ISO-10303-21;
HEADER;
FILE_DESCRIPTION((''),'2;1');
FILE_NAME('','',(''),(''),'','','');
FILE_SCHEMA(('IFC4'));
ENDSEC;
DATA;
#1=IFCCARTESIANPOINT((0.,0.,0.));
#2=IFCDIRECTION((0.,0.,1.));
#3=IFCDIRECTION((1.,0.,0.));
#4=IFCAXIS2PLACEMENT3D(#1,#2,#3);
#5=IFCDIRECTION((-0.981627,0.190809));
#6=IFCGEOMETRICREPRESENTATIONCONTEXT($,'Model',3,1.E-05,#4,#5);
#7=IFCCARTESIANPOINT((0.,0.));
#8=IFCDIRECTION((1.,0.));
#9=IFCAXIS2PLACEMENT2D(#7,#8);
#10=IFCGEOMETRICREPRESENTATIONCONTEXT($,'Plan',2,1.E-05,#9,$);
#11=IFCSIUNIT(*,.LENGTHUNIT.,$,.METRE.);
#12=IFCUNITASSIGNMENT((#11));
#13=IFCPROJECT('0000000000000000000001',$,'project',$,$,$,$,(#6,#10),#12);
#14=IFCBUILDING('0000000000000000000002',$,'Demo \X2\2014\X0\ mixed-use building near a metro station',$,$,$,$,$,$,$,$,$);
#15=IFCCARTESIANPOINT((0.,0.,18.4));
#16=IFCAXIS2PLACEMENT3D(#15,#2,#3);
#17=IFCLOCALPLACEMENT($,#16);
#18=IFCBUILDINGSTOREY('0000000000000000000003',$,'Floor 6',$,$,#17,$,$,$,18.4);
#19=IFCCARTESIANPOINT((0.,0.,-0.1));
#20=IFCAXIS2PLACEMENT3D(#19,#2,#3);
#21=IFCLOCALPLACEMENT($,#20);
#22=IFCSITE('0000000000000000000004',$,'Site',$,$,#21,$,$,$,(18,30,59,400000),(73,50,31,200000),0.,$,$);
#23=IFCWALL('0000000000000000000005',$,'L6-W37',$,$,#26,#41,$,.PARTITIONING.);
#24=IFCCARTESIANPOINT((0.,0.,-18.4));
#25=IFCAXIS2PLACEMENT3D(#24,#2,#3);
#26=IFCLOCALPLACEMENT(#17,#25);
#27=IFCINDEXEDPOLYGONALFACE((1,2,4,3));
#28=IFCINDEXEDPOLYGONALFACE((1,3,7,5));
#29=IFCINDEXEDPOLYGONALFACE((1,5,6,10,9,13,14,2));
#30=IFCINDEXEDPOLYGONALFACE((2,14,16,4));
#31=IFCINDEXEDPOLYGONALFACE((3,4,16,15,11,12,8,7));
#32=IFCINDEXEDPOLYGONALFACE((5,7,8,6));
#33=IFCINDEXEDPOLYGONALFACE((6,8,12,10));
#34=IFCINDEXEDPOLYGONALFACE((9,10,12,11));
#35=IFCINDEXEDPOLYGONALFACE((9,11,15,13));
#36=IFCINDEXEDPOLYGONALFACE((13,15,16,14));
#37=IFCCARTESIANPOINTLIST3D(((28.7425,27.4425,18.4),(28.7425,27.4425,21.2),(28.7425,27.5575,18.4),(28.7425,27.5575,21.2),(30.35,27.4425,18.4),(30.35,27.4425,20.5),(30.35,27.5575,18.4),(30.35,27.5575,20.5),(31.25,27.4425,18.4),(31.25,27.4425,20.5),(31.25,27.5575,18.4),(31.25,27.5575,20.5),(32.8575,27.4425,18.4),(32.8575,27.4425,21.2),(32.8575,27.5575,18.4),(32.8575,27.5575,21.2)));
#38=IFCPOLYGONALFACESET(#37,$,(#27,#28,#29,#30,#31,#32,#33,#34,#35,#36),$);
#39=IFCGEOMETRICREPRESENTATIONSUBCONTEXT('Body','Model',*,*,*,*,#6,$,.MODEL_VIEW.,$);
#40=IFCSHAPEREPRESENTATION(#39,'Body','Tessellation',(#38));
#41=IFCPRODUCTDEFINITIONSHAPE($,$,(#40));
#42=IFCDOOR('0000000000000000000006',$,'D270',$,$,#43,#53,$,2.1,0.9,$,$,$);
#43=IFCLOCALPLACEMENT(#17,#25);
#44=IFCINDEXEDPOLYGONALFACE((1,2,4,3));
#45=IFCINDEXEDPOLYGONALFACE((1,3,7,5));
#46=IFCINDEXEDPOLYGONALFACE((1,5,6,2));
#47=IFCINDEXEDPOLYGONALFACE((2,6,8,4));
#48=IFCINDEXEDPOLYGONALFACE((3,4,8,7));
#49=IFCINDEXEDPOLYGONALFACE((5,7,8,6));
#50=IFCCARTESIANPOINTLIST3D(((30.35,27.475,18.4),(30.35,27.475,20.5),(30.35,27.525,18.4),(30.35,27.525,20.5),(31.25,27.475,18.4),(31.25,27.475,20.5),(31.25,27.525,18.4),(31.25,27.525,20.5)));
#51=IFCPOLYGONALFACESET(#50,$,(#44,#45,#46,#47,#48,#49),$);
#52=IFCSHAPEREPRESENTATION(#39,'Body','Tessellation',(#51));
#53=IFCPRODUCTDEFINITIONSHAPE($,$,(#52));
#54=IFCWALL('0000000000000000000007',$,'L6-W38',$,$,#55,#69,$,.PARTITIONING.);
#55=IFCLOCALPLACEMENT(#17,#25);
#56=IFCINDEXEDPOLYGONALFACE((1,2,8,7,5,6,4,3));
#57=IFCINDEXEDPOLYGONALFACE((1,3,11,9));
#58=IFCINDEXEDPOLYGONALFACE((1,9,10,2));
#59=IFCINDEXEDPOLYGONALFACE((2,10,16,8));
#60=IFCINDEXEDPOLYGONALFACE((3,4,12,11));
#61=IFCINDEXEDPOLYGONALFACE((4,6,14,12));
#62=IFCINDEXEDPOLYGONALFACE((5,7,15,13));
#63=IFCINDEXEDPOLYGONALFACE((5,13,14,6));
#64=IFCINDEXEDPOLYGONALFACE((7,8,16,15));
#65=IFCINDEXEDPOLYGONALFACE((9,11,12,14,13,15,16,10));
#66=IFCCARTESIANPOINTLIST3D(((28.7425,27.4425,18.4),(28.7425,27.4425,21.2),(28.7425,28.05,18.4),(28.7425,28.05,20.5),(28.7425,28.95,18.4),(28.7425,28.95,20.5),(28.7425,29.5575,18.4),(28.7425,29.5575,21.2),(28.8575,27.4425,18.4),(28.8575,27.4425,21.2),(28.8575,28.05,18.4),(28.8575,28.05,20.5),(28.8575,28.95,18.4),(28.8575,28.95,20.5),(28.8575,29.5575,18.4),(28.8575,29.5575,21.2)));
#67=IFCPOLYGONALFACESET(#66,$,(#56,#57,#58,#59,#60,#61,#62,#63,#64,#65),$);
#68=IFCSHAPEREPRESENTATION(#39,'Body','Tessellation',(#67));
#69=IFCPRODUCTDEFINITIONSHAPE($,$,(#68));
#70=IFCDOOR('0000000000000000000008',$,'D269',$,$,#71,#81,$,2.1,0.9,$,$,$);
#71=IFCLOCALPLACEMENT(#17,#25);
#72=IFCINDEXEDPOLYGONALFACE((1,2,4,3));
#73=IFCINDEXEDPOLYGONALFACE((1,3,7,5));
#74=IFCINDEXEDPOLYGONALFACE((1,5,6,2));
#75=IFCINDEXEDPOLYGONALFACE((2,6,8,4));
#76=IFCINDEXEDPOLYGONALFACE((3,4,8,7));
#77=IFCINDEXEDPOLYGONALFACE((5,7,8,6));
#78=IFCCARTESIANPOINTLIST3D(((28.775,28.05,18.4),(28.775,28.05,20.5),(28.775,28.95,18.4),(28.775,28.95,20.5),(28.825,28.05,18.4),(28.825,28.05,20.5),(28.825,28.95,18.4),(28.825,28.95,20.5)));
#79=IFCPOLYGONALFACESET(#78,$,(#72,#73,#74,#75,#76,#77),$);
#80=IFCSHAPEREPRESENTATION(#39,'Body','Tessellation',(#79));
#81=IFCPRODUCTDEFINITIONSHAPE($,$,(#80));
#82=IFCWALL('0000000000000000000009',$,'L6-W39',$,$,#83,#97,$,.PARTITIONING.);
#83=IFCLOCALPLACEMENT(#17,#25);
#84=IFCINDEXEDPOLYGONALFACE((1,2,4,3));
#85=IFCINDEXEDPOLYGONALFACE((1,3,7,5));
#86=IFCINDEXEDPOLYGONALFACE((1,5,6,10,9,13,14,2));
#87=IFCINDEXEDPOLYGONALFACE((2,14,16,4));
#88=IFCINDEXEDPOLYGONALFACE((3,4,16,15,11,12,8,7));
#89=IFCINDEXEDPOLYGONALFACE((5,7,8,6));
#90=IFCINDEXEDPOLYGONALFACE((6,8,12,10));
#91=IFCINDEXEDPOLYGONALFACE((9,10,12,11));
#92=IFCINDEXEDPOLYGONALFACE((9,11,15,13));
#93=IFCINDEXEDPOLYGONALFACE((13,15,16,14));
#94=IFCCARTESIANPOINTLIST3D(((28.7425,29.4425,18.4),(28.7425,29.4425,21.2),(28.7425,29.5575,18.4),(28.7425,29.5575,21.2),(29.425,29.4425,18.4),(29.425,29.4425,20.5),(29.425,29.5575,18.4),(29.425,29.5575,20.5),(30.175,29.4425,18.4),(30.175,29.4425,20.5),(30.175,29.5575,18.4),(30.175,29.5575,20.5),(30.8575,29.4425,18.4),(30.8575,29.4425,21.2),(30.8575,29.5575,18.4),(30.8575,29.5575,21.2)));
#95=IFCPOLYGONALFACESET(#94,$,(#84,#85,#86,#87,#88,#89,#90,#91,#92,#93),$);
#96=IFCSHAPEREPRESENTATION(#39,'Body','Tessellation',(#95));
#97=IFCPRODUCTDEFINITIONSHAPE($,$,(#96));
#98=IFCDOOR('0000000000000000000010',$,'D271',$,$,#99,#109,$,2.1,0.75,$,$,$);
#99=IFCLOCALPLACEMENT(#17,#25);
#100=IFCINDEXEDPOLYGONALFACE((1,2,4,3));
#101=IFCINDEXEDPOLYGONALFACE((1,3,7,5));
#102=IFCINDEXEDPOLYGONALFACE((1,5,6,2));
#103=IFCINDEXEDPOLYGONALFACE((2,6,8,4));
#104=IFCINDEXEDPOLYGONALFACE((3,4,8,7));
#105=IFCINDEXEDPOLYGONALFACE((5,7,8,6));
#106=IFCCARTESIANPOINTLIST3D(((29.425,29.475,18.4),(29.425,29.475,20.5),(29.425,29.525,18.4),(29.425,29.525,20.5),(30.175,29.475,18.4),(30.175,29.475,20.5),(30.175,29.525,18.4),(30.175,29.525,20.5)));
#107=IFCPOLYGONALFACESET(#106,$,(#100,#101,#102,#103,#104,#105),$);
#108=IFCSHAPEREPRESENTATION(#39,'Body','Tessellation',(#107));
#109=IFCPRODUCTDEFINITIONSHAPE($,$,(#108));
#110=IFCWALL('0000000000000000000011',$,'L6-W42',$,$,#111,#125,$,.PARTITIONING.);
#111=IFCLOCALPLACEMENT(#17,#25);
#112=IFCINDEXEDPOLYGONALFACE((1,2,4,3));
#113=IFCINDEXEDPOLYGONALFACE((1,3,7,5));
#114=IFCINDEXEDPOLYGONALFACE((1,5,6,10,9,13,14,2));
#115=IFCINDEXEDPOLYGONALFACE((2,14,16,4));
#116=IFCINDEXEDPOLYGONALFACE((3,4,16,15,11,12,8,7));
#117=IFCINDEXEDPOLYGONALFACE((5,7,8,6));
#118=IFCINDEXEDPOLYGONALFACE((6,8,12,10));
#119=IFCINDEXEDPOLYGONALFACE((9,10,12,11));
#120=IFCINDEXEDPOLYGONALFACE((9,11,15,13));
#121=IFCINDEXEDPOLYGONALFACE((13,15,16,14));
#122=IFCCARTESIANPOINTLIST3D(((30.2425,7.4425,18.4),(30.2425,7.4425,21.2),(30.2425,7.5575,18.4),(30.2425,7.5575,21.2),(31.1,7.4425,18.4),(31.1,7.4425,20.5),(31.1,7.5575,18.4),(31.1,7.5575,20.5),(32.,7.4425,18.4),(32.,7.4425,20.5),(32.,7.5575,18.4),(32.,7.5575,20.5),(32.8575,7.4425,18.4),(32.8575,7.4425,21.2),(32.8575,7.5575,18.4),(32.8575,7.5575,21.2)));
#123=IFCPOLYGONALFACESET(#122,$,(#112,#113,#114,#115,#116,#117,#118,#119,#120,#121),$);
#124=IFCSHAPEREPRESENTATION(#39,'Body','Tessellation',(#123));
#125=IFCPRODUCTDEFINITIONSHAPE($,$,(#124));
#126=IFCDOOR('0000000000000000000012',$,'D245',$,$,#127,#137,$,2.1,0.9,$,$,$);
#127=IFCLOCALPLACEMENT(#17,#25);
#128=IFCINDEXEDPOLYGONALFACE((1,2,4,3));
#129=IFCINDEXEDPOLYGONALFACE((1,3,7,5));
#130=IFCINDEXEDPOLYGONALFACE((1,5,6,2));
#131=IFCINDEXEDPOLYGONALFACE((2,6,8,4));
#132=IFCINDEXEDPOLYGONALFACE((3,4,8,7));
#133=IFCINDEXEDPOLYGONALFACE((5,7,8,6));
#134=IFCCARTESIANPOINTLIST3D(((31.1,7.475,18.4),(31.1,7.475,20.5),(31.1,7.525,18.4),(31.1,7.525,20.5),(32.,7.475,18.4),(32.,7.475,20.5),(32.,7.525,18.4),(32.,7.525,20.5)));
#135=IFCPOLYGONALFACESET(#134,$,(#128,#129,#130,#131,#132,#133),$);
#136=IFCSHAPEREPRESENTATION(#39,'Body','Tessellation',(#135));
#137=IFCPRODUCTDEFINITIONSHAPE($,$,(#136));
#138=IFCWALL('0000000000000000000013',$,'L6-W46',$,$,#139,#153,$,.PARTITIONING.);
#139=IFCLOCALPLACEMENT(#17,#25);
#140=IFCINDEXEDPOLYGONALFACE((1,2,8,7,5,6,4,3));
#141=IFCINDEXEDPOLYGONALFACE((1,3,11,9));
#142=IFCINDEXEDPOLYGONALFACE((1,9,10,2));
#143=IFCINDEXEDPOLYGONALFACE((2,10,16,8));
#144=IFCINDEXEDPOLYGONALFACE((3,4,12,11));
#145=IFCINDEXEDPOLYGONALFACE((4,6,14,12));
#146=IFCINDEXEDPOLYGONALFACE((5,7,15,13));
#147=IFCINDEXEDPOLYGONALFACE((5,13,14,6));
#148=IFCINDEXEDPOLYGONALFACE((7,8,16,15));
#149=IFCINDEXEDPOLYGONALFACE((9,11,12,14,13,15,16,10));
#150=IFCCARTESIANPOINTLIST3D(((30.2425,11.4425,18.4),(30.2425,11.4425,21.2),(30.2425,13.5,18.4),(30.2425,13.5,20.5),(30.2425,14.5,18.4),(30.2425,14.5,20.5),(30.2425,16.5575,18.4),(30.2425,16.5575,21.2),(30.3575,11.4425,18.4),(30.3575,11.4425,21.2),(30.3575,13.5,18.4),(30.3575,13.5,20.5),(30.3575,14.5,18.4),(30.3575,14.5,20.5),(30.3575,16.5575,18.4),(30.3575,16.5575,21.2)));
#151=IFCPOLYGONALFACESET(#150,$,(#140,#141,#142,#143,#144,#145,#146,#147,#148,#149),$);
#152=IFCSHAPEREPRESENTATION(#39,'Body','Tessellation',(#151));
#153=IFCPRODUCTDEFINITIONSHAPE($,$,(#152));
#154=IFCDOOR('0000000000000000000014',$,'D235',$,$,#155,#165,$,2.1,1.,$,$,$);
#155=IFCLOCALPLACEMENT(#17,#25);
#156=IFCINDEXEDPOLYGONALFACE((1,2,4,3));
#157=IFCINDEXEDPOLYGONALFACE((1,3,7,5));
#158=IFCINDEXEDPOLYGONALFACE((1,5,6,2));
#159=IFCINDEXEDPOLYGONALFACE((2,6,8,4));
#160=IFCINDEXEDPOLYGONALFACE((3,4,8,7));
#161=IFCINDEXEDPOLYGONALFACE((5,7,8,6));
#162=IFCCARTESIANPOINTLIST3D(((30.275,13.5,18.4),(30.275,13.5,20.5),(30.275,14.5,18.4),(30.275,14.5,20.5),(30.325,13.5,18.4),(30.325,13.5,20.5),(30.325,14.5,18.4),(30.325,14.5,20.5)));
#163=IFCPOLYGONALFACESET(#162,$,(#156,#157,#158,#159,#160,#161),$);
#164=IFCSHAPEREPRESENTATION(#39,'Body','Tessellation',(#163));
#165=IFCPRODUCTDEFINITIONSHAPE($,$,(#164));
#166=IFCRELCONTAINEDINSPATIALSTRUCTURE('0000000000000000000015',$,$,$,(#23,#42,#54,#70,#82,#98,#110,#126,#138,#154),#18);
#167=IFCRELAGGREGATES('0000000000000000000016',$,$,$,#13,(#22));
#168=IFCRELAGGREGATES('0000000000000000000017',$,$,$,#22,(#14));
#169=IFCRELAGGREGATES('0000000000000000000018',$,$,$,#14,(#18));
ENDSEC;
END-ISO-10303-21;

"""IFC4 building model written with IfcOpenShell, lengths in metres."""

from ifc_helpers import new_model, si_unit, direction, frame, origin_with_axes, origin_2d_with_axis, place, context, subcontext, project, spatial, line, indexed_curve, outline, extrude, element, fill, save


model = new_model("IFC4")

# Units and contexts
model_context = context("Model", 3, precision=1e-05, world=origin_with_axes(), true_north=direction((-0.981627, 0.190809)))
plan_context = context("Plan", 2, precision=1e-05, world=origin_2d_with_axis())
body_context = subcontext(model_context, "Body", "Model", "MODEL_VIEW")
ifc_project = project(units=[si_unit("LENGTHUNIT", "METRE")], contexts=[model_context, plan_context])

# Site, building, storey
site_placement = place(None, frame((0.0, 0.0, -0.1), z_axis=(0.0, 0.0, 1.0), x_axis=(1.0, 0.0, 0.0)))
site = spatial("IfcSite", under=ifc_project, at=site_placement, Name="Site", RefLatitude=(18, 30, 59, 400000), RefLongitude=(73, 50, 31, 200000), RefElevation=0.0)
building = spatial("IfcBuilding", under=site, Name="Demo — mixed-use building near a metro station")
storey_placement = place(None, frame((0.0, 0.0, 18.4), z_axis=(0.0, 0.0, 1.0), x_axis=(1.0, 0.0, 0.0)))
storey = spatial("IfcBuildingStorey", under=building, at=storey_placement, Name="Floor 6", Elevation=18.4)

# Walls, openings, doors
wall_1_placement = place(storey_placement, frame((0.0, 0.0, -18.4), z_axis=(0.0, 0.0, 1.0), x_axis=(1.0, 0.0, 0.0)))
wall_1 = element("IfcWall", 1, at=wall_1_placement, inside=storey, Name="L6-W37", PredefinedType="PARTITIONING", context=body_context, shape_type="SweptSolid", body=[
    extrude(outline(indexed_curve([(32.8575, 27.4425), (28.7425, 27.4425), (28.7425, 27.5575), (32.8575, 27.5575)], segments=[line(1, 2, 3, 4, 1)])), frame((0.0, 0.0, 18.4), z_axis=(0.0, 0.0, 1.0), x_axis=(1.0, 0.0, 0.0)), (0.0, 0.0, 1.0), 2.8),
])
opening_1_placement = place(wall_1_placement, origin_with_axes())
opening_1 = element("IfcOpeningElement", 2, at=opening_1_placement, cuts=wall_1, context=body_context, shape_type="SweptSolid", body=[
    extrude(outline(indexed_curve([(31.25, 27.3925), (30.35, 27.3925), (30.35, 27.6075), (31.25, 27.6075)], segments=[line(1, 2, 3, 4, 1)])), frame((0.0, 0.0, 18.4), z_axis=(0.0, 0.0, 1.0), x_axis=(1.0, 0.0, 0.0)), (0.0, 0.0, 1.0), 2.1),
])
door_1_placement = place(storey_placement, frame((0.0, 0.0, -18.4), z_axis=(0.0, 0.0, 1.0), x_axis=(1.0, 0.0, 0.0)))
door_1 = element("IfcDoor", 3, at=door_1_placement, inside=storey, Name="D270", OverallHeight=2.1, OverallWidth=0.9, context=body_context, shape_type="SweptSolid", body=[
    extrude(outline(indexed_curve([(31.25, 27.475), (30.35, 27.475), (30.35, 27.525), (31.25, 27.525)], segments=[line(1, 2, 3, 4, 1)])), frame((0.0, 0.0, 18.4), z_axis=(0.0, 0.0, 1.0), x_axis=(1.0, 0.0, 0.0)), (0.0, 0.0, 1.0), 2.1),
])
fill(opening_1, door_1)
wall_2_placement = place(storey_placement, frame((0.0, 0.0, -18.4), z_axis=(0.0, 0.0, 1.0), x_axis=(1.0, 0.0, 0.0)))
wall_2 = element("IfcWall", 4, at=wall_2_placement, inside=storey, Name="L6-W38", PredefinedType="PARTITIONING", context=body_context, shape_type="SweptSolid", body=[
    extrude(outline(indexed_curve([(28.7425, 27.4425), (28.7425, 29.5575), (28.8575, 29.5575), (28.8575, 27.4425)], segments=[line(1, 2, 3, 4, 1)])), frame((0.0, 0.0, 18.4), z_axis=(0.0, 0.0, 1.0), x_axis=(1.0, 0.0, 0.0)), (0.0, 0.0, 1.0), 2.8),
])
opening_2_placement = place(wall_2_placement, origin_with_axes())
opening_2 = element("IfcOpeningElement", 5, at=opening_2_placement, cuts=wall_2, context=body_context, shape_type="SweptSolid", body=[
    extrude(outline(indexed_curve([(28.6925, 28.05), (28.6925, 28.95), (28.9075, 28.95), (28.9075, 28.05)], segments=[line(1, 2, 3, 4, 1)])), frame((0.0, 0.0, 18.4), z_axis=(0.0, 0.0, 1.0), x_axis=(1.0, 0.0, 0.0)), (0.0, 0.0, 1.0), 2.1),
])
door_2_placement = place(storey_placement, frame((0.0, 0.0, -18.4), z_axis=(0.0, 0.0, 1.0), x_axis=(1.0, 0.0, 0.0)))
door_2 = element("IfcDoor", 6, at=door_2_placement, inside=storey, Name="D269", OverallHeight=2.1, OverallWidth=0.9, context=body_context, shape_type="SweptSolid", body=[
    extrude(outline(indexed_curve([(28.775, 28.05), (28.775, 28.95), (28.825, 28.95), (28.825, 28.05)], segments=[line(1, 2, 3, 4, 1)])), frame((0.0, 0.0, 18.4), z_axis=(0.0, 0.0, 1.0), x_axis=(1.0, 0.0, 0.0)), (0.0, 0.0, 1.0), 2.1),
])
fill(opening_2, door_2)
wall_3_placement = place(storey_placement, frame((0.0, 0.0, -18.4), z_axis=(0.0, 0.0, 1.0), x_axis=(1.0, 0.0, 0.0)))
wall_3 = element("IfcWall", 7, at=wall_3_placement, inside=storey, Name="L6-W39", PredefinedType="PARTITIONING", context=body_context, shape_type="SweptSolid", body=[
    extrude(outline(indexed_curve([(30.8575, 29.4425), (28.7425, 29.4425), (28.7425, 29.5575), (30.8575, 29.5575)], segments=[line(1, 2, 3, 4, 1)])), frame((0.0, 0.0, 18.4), z_axis=(0.0, 0.0, 1.0), x_axis=(1.0, 0.0, 0.0)), (0.0, 0.0, 1.0), 2.8),
])
opening_3_placement = place(wall_3_placement, origin_with_axes())
opening_3 = element("IfcOpeningElement", 8, at=opening_3_placement, cuts=wall_3, context=body_context, shape_type="SweptSolid", body=[
    extrude(outline(indexed_curve([(30.175, 29.3925), (29.425, 29.3925), (29.425, 29.6075), (30.175, 29.6075)], segments=[line(1, 2, 3, 4, 1)])), frame((0.0, 0.0, 18.4), z_axis=(0.0, 0.0, 1.0), x_axis=(1.0, 0.0, 0.0)), (0.0, 0.0, 1.0), 2.1),
])
door_3_placement = place(storey_placement, frame((0.0, 0.0, -18.4), z_axis=(0.0, 0.0, 1.0), x_axis=(1.0, 0.0, 0.0)))
door_3 = element("IfcDoor", 9, at=door_3_placement, inside=storey, Name="D271", OverallHeight=2.1, OverallWidth=0.75, context=body_context, shape_type="SweptSolid", body=[
    extrude(outline(indexed_curve([(30.175, 29.475), (29.425, 29.475), (29.425, 29.525), (30.175, 29.525)], segments=[line(1, 2, 3, 4, 1)])), frame((0.0, 0.0, 18.4), z_axis=(0.0, 0.0, 1.0), x_axis=(1.0, 0.0, 0.0)), (0.0, 0.0, 1.0), 2.1),
])
fill(opening_3, door_3)

# Wall, opening, door
wall_4_placement = place(storey_placement, frame((0.0, 0.0, -18.4), z_axis=(0.0, 0.0, 1.0), x_axis=(1.0, 0.0, 0.0)))
wall_4 = element("IfcWall", 10, at=wall_4_placement, inside=storey, Name="L6-W42", PredefinedType="PARTITIONING", context=body_context, shape_type="SweptSolid", body=[
    extrude(outline(indexed_curve([(32.8575, 7.4425), (30.2425, 7.4425), (30.2425, 7.5575), (32.8575, 7.5575)], segments=[line(1, 2, 3, 4, 1)])), frame((0.0, 0.0, 18.4), z_axis=(0.0, 0.0, 1.0), x_axis=(1.0, 0.0, 0.0)), (0.0, 0.0, 1.0), 2.8),
])
opening_4_placement = place(wall_4_placement, origin_with_axes())
opening_4 = element("IfcOpeningElement", 11, at=opening_4_placement, cuts=wall_4, context=body_context, shape_type="SweptSolid", body=[
    extrude(outline(indexed_curve([(32.0, 7.3925), (31.1, 7.3925), (31.1, 7.6075), (32.0, 7.6075)], segments=[line(1, 2, 3, 4, 1)])), frame((0.0, 0.0, 18.4), z_axis=(0.0, 0.0, 1.0), x_axis=(1.0, 0.0, 0.0)), (0.0, 0.0, 1.0), 2.1),
])
door_4_placement = place(storey_placement, frame((0.0, 0.0, -18.4), z_axis=(0.0, 0.0, 1.0), x_axis=(1.0, 0.0, 0.0)))
door_4 = element("IfcDoor", 12, at=door_4_placement, inside=storey, Name="D245", OverallHeight=2.1, OverallWidth=0.9, context=body_context, shape_type="SweptSolid", body=[
    extrude(outline(indexed_curve([(32.0, 7.475), (31.1, 7.475), (31.1, 7.525), (32.0, 7.525)], segments=[line(1, 2, 3, 4, 1)])), frame((0.0, 0.0, 18.4), z_axis=(0.0, 0.0, 1.0), x_axis=(1.0, 0.0, 0.0)), (0.0, 0.0, 1.0), 2.1),
])
fill(opening_4, door_4)

# Wall, opening, door
wall_5_placement = place(storey_placement, frame((0.0, 0.0, -18.4), z_axis=(0.0, 0.0, 1.0), x_axis=(1.0, 0.0, 0.0)))
wall_5 = element("IfcWall", 13, at=wall_5_placement, inside=storey, Name="L6-W46", PredefinedType="PARTITIONING", context=body_context, shape_type="SweptSolid", body=[
    extrude(outline(indexed_curve([(30.2425, 11.4425), (30.2425, 16.5575), (30.3575, 16.5575), (30.3575, 11.4425)], segments=[line(1, 2, 3, 4, 1)])), frame((0.0, 0.0, 18.4), z_axis=(0.0, 0.0, 1.0), x_axis=(1.0, 0.0, 0.0)), (0.0, 0.0, 1.0), 2.8),
])
opening_5_placement = place(wall_5_placement, origin_with_axes())
opening_5 = element("IfcOpeningElement", 14, at=opening_5_placement, cuts=wall_5, context=body_context, shape_type="SweptSolid", body=[
    extrude(outline(indexed_curve([(30.1925, 13.5), (30.1925, 14.5), (30.4075, 14.5), (30.4075, 13.5)], segments=[line(1, 2, 3, 4, 1)])), frame((0.0, 0.0, 18.4), z_axis=(0.0, 0.0, 1.0), x_axis=(1.0, 0.0, 0.0)), (0.0, 0.0, 1.0), 2.1),
])
door_5_placement = place(storey_placement, frame((0.0, 0.0, -18.4), z_axis=(0.0, 0.0, 1.0), x_axis=(1.0, 0.0, 0.0)))
door_5 = element("IfcDoor", 15, at=door_5_placement, inside=storey, Name="D235", OverallHeight=2.1, OverallWidth=1.0, context=body_context, shape_type="SweptSolid", body=[
    extrude(outline(indexed_curve([(30.275, 13.5), (30.275, 14.5), (30.325, 14.5), (30.325, 13.5)], segments=[line(1, 2, 3, 4, 1)])), frame((0.0, 0.0, 18.4), z_axis=(0.0, 0.0, 1.0), x_axis=(1.0, 0.0, 0.0)), (0.0, 0.0, 1.0), 2.1),
])
fill(opening_5, door_5)

save(model, "model.ifc")
